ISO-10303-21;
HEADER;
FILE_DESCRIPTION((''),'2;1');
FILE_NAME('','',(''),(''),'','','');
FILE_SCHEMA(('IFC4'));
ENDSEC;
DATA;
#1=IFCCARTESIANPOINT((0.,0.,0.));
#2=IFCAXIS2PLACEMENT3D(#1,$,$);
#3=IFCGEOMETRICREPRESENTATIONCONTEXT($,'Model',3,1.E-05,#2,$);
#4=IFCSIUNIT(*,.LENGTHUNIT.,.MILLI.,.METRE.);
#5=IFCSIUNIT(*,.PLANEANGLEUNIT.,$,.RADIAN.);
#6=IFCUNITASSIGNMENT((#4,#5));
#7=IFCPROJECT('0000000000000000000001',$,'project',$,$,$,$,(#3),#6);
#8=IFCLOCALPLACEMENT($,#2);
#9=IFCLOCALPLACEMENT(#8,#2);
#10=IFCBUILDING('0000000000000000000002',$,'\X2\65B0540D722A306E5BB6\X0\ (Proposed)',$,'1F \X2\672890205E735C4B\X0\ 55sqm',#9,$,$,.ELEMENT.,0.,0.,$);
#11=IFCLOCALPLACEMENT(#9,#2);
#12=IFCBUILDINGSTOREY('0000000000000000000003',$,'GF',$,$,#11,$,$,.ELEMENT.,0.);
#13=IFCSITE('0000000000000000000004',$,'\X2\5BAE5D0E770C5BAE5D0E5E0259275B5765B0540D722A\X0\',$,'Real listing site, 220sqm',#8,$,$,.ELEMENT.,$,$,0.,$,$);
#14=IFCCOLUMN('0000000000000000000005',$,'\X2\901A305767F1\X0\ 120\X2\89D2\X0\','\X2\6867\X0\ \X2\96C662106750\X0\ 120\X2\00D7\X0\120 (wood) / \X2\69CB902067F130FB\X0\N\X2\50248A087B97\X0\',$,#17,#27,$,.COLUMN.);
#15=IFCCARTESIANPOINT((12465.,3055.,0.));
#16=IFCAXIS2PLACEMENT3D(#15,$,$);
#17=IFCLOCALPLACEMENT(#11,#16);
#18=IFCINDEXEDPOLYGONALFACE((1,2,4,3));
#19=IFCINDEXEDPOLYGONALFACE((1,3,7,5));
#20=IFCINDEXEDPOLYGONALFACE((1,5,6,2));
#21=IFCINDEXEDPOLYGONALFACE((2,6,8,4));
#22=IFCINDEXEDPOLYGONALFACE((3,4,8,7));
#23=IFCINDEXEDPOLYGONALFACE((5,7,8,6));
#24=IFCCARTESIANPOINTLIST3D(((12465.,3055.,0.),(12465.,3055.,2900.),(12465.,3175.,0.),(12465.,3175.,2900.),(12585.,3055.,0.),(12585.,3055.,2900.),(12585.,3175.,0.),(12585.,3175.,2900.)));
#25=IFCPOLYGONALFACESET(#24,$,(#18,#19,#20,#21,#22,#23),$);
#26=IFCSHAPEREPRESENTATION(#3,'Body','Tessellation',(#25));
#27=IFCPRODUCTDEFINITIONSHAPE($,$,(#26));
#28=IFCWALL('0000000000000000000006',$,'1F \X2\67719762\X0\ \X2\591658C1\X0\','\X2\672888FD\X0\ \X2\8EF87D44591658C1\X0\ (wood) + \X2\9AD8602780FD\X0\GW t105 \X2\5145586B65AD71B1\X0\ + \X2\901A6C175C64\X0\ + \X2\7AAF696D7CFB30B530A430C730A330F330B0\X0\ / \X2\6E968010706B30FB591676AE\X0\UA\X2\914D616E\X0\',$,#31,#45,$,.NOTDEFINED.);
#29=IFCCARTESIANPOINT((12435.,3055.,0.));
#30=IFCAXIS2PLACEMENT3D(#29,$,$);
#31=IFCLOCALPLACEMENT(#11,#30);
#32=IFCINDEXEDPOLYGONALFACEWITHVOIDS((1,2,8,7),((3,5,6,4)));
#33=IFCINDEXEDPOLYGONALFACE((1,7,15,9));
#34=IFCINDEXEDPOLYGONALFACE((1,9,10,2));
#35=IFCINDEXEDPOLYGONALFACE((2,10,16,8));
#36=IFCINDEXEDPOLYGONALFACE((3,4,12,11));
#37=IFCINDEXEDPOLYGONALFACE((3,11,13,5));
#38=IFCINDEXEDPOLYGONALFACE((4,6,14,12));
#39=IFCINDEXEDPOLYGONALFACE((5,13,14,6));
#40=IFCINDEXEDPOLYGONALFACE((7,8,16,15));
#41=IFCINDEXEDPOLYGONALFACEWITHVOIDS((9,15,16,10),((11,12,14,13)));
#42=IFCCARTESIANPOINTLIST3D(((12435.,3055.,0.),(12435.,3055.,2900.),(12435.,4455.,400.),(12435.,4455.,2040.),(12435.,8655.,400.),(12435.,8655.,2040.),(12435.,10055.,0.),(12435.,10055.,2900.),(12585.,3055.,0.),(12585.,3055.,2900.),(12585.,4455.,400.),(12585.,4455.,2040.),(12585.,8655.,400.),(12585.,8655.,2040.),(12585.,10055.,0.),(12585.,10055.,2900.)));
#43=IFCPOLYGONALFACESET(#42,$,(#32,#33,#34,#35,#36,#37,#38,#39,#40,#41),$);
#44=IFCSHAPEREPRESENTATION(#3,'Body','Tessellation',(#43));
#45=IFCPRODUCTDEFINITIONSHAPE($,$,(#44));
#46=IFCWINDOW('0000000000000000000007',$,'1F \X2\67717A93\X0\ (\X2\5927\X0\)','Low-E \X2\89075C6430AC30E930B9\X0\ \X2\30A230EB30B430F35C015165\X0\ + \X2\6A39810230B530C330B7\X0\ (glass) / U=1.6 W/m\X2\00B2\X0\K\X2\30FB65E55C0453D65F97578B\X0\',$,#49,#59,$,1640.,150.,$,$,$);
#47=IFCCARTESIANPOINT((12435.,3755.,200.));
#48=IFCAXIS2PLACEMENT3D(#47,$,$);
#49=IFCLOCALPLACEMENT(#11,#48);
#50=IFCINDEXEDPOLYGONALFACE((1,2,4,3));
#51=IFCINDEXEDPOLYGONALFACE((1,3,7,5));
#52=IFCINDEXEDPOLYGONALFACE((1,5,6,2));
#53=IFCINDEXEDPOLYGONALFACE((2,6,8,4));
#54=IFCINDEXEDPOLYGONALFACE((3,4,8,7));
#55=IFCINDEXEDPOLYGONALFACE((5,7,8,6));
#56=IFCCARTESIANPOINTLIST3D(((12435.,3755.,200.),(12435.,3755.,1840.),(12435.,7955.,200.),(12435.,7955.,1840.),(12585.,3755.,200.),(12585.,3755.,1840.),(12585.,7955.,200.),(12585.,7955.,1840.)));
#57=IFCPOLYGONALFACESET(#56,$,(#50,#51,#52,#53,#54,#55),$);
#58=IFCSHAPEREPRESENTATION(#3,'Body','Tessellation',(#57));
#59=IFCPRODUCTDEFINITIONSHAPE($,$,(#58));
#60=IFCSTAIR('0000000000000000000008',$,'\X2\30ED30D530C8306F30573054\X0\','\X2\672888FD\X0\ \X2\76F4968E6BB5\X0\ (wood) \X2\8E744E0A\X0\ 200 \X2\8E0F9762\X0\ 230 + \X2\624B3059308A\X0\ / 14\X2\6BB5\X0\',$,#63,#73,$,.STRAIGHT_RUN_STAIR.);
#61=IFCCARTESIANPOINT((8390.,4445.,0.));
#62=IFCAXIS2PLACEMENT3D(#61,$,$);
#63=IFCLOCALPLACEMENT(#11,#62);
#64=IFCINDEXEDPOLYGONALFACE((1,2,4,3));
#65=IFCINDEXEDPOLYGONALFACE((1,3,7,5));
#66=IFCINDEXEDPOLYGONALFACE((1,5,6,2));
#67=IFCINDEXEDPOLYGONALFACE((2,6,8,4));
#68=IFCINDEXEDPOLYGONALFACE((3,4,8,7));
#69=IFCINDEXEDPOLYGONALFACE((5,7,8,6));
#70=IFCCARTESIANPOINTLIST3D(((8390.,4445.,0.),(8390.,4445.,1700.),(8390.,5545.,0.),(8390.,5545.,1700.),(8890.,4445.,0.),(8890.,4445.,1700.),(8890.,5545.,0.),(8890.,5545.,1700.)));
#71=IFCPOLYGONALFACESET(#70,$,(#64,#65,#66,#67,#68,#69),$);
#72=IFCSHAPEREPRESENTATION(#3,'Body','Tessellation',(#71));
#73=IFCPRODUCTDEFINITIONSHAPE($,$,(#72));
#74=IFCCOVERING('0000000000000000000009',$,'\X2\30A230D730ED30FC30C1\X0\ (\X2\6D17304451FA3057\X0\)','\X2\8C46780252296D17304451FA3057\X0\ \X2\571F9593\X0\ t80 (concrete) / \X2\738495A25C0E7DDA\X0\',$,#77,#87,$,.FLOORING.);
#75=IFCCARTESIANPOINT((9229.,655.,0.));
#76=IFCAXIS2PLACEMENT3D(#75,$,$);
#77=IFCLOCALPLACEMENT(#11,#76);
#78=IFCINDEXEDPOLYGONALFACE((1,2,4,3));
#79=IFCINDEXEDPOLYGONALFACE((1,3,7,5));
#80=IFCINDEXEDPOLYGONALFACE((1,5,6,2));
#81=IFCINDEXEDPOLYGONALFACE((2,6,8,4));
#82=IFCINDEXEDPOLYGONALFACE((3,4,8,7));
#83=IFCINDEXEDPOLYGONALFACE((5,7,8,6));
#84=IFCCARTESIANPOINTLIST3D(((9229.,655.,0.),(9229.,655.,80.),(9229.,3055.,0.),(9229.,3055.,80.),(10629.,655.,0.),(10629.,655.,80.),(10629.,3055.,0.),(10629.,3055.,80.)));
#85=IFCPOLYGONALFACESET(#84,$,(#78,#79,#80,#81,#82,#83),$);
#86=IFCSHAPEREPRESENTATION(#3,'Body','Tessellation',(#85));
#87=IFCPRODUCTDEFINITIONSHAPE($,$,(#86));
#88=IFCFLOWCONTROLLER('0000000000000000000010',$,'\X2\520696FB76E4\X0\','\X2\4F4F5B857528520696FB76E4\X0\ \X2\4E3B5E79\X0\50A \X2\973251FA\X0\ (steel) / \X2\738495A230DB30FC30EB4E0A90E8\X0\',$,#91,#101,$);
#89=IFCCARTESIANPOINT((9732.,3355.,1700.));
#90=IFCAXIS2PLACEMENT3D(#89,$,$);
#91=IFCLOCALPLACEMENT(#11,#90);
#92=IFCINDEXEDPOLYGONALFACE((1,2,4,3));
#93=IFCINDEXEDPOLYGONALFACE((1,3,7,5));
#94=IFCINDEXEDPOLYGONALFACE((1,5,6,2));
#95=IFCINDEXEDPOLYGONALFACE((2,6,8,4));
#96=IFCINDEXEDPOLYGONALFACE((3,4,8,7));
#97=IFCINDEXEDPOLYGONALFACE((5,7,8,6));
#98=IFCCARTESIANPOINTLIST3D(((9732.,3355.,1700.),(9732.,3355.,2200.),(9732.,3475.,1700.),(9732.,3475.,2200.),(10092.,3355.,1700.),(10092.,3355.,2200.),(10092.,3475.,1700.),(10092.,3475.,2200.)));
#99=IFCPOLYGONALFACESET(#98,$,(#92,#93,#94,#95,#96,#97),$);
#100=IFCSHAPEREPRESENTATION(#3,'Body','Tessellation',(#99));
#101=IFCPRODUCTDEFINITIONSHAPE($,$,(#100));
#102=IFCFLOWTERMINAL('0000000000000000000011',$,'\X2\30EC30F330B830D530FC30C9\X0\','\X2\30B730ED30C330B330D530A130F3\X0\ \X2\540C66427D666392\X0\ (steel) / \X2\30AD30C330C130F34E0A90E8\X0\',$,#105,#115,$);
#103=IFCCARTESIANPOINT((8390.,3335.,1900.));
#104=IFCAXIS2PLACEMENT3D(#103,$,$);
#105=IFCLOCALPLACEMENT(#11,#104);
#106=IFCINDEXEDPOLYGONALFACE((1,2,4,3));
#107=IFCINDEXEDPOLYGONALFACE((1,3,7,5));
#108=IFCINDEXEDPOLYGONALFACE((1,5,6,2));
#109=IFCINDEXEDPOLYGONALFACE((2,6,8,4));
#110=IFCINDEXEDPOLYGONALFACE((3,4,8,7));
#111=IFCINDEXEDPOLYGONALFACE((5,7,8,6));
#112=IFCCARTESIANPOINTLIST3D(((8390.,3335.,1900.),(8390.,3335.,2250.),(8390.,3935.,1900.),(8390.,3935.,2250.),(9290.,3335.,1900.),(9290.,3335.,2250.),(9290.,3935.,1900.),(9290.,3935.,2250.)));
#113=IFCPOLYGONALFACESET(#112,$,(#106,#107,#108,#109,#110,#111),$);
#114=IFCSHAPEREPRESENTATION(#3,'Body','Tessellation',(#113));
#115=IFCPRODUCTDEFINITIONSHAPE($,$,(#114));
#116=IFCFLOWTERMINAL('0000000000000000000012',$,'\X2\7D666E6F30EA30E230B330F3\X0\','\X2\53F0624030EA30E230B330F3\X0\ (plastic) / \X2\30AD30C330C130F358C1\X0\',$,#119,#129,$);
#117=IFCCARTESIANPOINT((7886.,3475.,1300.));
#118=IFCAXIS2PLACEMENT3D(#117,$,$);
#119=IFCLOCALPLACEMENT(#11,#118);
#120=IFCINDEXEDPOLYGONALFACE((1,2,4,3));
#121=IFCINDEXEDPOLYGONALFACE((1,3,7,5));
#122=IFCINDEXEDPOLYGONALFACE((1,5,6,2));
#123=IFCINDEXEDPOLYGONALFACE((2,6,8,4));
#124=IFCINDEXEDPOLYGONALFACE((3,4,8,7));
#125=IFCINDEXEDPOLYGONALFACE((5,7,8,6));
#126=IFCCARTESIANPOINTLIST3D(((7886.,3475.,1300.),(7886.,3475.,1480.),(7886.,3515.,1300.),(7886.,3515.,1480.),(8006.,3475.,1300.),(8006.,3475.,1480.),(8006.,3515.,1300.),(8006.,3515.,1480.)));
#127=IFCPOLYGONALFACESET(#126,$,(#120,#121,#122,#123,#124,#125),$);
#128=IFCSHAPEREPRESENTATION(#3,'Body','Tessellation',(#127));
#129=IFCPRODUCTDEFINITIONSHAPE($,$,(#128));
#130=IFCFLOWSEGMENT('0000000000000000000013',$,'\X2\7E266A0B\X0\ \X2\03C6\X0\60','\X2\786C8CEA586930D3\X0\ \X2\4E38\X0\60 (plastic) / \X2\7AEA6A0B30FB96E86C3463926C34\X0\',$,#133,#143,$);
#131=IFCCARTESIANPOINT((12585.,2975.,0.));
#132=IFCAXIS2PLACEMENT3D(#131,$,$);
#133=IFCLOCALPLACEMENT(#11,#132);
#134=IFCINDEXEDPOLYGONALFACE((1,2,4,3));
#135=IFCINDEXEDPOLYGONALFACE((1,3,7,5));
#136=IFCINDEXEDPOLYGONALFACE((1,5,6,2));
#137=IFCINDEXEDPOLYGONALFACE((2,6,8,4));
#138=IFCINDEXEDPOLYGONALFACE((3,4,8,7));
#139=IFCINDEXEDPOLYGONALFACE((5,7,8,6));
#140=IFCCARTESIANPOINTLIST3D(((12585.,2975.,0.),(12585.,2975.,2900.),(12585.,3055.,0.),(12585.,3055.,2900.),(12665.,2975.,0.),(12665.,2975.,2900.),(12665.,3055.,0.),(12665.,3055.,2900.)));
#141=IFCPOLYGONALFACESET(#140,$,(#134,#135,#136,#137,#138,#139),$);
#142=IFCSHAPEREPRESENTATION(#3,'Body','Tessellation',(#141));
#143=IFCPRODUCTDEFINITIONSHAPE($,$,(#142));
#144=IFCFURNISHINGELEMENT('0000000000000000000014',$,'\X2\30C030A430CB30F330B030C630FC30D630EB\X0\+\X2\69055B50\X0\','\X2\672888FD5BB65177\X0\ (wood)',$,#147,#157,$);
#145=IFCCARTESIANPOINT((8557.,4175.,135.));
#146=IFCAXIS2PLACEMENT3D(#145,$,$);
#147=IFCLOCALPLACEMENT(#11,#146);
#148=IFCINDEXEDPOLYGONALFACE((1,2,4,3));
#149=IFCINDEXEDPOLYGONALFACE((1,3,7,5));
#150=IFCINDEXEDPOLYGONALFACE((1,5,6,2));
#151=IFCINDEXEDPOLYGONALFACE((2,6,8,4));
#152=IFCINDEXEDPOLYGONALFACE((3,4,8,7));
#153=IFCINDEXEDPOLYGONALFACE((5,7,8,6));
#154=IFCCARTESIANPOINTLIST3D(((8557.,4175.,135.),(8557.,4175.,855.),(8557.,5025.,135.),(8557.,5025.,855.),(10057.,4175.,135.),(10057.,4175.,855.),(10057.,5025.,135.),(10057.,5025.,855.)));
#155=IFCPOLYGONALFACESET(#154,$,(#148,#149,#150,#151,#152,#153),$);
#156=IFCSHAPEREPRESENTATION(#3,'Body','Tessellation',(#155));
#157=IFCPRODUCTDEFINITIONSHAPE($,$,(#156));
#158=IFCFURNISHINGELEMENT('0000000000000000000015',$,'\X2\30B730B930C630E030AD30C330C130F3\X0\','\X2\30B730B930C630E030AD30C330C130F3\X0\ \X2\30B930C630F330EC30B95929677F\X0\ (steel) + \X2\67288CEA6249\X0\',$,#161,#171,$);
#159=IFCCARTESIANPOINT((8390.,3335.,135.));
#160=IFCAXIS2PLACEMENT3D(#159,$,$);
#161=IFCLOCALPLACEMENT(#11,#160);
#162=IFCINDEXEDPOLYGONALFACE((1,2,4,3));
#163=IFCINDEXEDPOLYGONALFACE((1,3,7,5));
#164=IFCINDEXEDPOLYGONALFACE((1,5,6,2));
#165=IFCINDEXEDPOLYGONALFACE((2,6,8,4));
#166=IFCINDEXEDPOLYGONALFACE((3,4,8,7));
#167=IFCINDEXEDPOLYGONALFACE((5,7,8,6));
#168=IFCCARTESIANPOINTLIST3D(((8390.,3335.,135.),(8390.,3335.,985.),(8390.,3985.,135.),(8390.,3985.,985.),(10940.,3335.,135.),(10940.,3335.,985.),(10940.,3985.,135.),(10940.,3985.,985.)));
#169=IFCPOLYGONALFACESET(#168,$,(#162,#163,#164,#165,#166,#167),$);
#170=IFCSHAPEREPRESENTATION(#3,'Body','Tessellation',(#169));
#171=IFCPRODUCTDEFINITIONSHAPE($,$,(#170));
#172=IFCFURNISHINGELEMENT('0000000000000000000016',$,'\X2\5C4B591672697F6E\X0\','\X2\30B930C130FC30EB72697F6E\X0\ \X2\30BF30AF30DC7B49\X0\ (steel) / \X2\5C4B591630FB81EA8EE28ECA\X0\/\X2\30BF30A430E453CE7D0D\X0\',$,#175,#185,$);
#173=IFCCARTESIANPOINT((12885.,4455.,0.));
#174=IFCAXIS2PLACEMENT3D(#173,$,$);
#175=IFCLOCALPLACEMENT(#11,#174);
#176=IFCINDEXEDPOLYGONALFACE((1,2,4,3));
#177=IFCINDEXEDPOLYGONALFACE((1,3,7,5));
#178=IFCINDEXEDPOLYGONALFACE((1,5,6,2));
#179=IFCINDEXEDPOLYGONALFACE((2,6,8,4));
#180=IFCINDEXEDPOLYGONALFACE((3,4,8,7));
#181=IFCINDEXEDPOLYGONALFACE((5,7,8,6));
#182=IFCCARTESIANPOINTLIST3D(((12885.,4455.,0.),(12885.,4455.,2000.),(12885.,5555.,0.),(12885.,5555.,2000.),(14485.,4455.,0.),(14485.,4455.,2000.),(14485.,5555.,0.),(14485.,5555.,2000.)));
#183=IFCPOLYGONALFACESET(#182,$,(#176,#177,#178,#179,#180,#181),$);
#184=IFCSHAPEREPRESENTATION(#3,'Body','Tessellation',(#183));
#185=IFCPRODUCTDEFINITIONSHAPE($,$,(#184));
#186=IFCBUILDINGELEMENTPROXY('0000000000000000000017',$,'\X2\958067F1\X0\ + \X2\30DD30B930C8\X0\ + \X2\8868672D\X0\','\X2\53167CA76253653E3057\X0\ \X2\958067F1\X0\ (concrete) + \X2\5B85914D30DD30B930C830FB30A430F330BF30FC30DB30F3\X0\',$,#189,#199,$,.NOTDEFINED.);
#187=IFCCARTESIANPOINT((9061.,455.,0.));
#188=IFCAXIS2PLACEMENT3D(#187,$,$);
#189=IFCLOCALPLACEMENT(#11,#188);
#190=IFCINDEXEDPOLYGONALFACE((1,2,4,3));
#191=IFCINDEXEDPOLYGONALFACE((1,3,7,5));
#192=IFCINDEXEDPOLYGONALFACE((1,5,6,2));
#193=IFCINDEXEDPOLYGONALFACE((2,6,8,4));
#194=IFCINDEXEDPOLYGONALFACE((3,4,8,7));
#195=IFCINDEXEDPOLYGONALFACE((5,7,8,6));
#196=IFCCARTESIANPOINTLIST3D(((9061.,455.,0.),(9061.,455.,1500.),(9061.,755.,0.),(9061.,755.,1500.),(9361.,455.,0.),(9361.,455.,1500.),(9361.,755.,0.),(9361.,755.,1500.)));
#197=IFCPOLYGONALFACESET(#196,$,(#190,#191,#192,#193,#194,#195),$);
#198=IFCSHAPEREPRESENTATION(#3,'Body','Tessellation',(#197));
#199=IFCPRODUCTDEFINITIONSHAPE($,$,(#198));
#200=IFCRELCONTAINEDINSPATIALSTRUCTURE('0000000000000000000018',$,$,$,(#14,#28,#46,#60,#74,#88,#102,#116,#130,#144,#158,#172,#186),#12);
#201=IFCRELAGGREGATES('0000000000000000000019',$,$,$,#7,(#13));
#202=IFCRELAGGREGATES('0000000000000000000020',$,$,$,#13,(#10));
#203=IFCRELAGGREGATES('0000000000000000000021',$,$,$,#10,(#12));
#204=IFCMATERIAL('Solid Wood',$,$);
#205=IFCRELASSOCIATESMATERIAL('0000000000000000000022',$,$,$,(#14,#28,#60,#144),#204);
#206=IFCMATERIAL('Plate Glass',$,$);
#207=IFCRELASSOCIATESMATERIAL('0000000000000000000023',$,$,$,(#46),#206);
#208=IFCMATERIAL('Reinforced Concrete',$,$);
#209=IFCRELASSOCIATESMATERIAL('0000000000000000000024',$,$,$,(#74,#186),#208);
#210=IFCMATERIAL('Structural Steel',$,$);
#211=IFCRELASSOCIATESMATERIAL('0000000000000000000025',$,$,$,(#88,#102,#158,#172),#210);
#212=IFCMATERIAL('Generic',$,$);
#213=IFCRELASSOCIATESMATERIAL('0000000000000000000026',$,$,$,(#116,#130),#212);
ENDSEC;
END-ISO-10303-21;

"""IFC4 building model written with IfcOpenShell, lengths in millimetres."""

from ifc_helpers import new_model, si_unit, frame, frame_2d, origin, place, context, project, spatial, rectangle, extrude, material, element, fill, save


model = new_model("IFC4")

# Units and contexts
model_context = context("Model", 3, precision=1e-05, world=origin())
ifc_project = project(units=[si_unit("LENGTHUNIT", "METRE", prefix="MILLI"), si_unit("PLANEANGLEUNIT", "RADIAN")], contexts=[model_context])

# Site, building, storey
site_placement = place(None, origin())
site = spatial("IfcSite", under=ifc_project, at=site_placement, Name="宮崎県宮崎市大字新名爪", ObjectType="Real listing site, 220sqm", CompositionType="ELEMENT", RefElevation=0.0)
building_placement = place(site_placement, origin())
building = spatial("IfcBuilding", under=site, at=building_placement, Name="新名爪の家 (Proposed)", ObjectType="1F 木造平屋 55sqm", CompositionType="ELEMENT", ElevationOfRefHeight=0.0, ElevationOfTerrain=0.0)
storey_placement = place(building_placement, origin())
storey = spatial("IfcBuildingStorey", under=building, at=storey_placement, Name="GF", CompositionType="ELEMENT", Elevation=0.0)

# Column
ifc_material_1 = material(Name="Solid Wood")
column_1_placement = place(storey_placement, frame((12465.0, 3055.0, 0.0)))
element("IfcColumn", 1, at=column_1_placement, inside=storey, material=ifc_material_1, Name="通し柱 120角", Description="桧 集成材 120×120 (wood) / 構造柱・N値計算", PredefinedType="COLUMN", context=model_context, shape_type="SweptSolid", body=[
    extrude(rectangle(XDim=120.0, YDim=120.0, at=frame_2d((60.0, 60.0))), frame((12465.0, 3055.0, 0.0)), (0.0, 0.0, 1.0), 2900.0),
])

# Wall, opening, window
wall_1_placement = place(storey_placement, frame((12435.0, 3055.0, 0.0)))
wall_1 = element("IfcWall", 2, at=wall_1_placement, inside=storey, material=ifc_material_1, Name="1F 東面 外壁", Description="木製 軸組外壁 (wood) + 高性能GW t105 充填断熱 + 通気層 + 窯業系サイディング / 準耐火・外皮UA配慮", PredefinedType="NOTDEFINED", context=model_context, shape_type="SweptSolid", body=[
    extrude(rectangle(XDim=150.0, YDim=7000.0, at=frame_2d((75.0, 3500.0))), frame((12435.0, 3055.0, 0.0)), (0.0, 0.0, 1.0), 2900.0),
])
opening_placement = place(storey_placement, frame((12435.0, 3755.0, 200.0)))
opening = element("IfcOpeningElement", 3, at=opening_placement, cuts=wall_1, PredefinedType="NOTDEFINED", context=model_context, shape_type="SweptSolid", body=[
    extrude(rectangle(XDim=150.0, YDim=4200.0, at=frame_2d((75.0, 2100.0))), frame((12435.0, 3755.0, 200.0)), (0.0, 0.0, 1.0), 1640.0),
])
ifc_material_2 = material(Name="Plate Glass")
window_placement = place(storey_placement, frame((12435.0, 3755.0, 200.0)))
window = element("IfcWindow", 4, at=window_placement, inside=storey, material=ifc_material_2, Name="1F 東窓 (大)", Description="Low-E 複層ガラス アルゴン封入 + 樹脂サッシ (glass) / U=1.6 W/m²K・日射取得型", OverallHeight=1640.0, OverallWidth=150.0, context=model_context, shape_type="SweptSolid", body=[
    extrude(rectangle(XDim=150.0, YDim=4200.0, at=frame_2d((75.0, 2100.0))), frame((12435.0, 3755.0, 200.0)), (0.0, 0.0, 1.0), 1640.0),
])
fill(opening, window)

# Stair
stair_placement = place(storey_placement, frame((8390.0, 4445.0, 0.0)))
element("IfcStair", 5, at=stair_placement, inside=storey, material=ifc_material_1, Name="ロフトはしご", Description="木製 直階段 (wood) 蹴上 200 踏面 230 + 手すり / 14段", PredefinedType="STRAIGHT_RUN_STAIR", context=model_context, shape_type="SweptSolid", body=[
    extrude(rectangle(XDim=500.0, YDim=1100.0, at=frame_2d((250.0, 550.0))), frame((8390.0, 4445.0, 0.0)), (0.0, 0.0, 1.0), 1700.0),
])

# Covering
ifc_material_3 = material(Name="Reinforced Concrete")
covering_placement = place(storey_placement, frame((9229.0, 655.0, 0.0)))
element("IfcCovering", 6, at=covering_placement, inside=storey, material=ifc_material_3, Name="アプローチ (洗い出し)", Description="豆砂利洗い出し 土間 t80 (concrete) / 玄関導線", PredefinedType="FLOORING", context=model_context, shape_type="SweptSolid", body=[
    extrude(rectangle(XDim=1400.0, YDim=2400.0, at=frame_2d((700.0, 1200.0))), frame((9229.0, 655.0, 0.0)), (0.0, 0.0, 1.0), 80.0),
])

# Flow controller
ifc_material_4 = material(Name="Structural Steel")
flow_controller_placement = place(storey_placement, frame((9732.0, 3355.0, 1700.0)))
element("IfcFlowController", 7, at=flow_controller_placement, inside=storey, material=ifc_material_4, Name="分電盤", Description="住宅用分電盤 主幹50A 露出 (steel) / 玄関ホール上部", context=model_context, shape_type="SweptSolid", body=[
    extrude(rectangle(XDim=360.0, YDim=120.0, at=frame_2d((180.0, 60.0))), frame((9732.0, 3355.0, 1700.0)), (0.0, 0.0, 1.0), 500.0),
])

# Flow terminals
flow_terminal_1_placement = place(storey_placement, frame((8390.0, 3335.0, 1900.0)))
element("IfcFlowTerminal", 8, at=flow_terminal_1_placement, inside=storey, material=ifc_material_4, Name="レンジフード", Description="シロッコファン 同時給排 (steel) / キッチン上部", context=model_context, shape_type="SweptSolid", body=[
    extrude(rectangle(XDim=900.0, YDim=600.0, at=frame_2d((450.0, 300.0))), frame((8390.0, 3335.0, 1900.0)), (0.0, 0.0, 1.0), 350.0),
])
ifc_material_5 = material(Name="Generic")
flow_terminal_2_placement = place(storey_placement, frame((7886.0, 3475.0, 1300.0)))
element("IfcFlowTerminal", 9, at=flow_terminal_2_placement, inside=storey, material=ifc_material_5, Name="給湯リモコン", Description="台所リモコン (plastic) / キッチン壁", context=model_context, shape_type="SweptSolid", body=[
    extrude(rectangle(XDim=120.0, YDim=40.0, at=frame_2d((60.0, 20.0))), frame((7886.0, 3475.0, 1300.0)), (0.0, 0.0, 1.0), 180.0),
])

# Flow segment
flow_segment_placement = place(storey_placement, frame((12585.0, 2975.0, 0.0)))
element("IfcFlowSegment", 10, at=flow_segment_placement, inside=storey, material=ifc_material_5, Name="縦樋 φ60", Description="硬質塩ビ 丸60 (plastic) / 竪樋・雨水排水", context=model_context, shape_type="SweptSolid", body=[
    extrude(rectangle(XDim=80.0, YDim=80.0, at=frame_2d((40.0, 40.0))), frame((12585.0, 2975.0, 0.0)), (0.0, 0.0, 1.0), 2900.0),
])

# Furnishing elements
furnishing_1_placement = place(storey_placement, frame((8557.0, 4175.0, 135.0)))
element("IfcFurnishingElement", 11, at=furnishing_1_placement, inside=storey, material=ifc_material_1, Name="ダイニングテーブル+椅子", Description="木製家具 (wood)", context=model_context, shape_type="SweptSolid", body=[
    extrude(rectangle(XDim=1500.0, YDim=850.0, at=frame_2d((750.0, 425.0))), frame((8557.0, 4175.0, 135.0)), (0.0, 0.0, 1.0), 720.0),
])
furnishing_2_placement = place(storey_placement, frame((8390.0, 3335.0, 135.0)))
element("IfcFurnishingElement", 12, at=furnishing_2_placement, inside=storey, material=ifc_material_4, Name="システムキッチン", Description="システムキッチン ステンレス天板 (steel) + 木質扉", context=model_context, shape_type="SweptSolid", body=[
    extrude(rectangle(XDim=2550.0, YDim=650.0, at=frame_2d((1275.0, 325.0))), frame((8390.0, 3335.0, 135.0)), (0.0, 0.0, 1.0), 850.0),
])
furnishing_3_placement = place(storey_placement, frame((12885.0, 4455.0, 0.0)))
element("IfcFurnishingElement", 13, at=furnishing_3_placement, inside=storey, material=ifc_material_4, Name="屋外物置", Description="スチール物置 タクボ等 (steel) / 屋外・自転車/タイヤ収納", context=model_context, shape_type="SweptSolid", body=[
    extrude(rectangle(XDim=1600.0, YDim=1100.0, at=frame_2d((800.0, 550.0))), frame((12885.0, 4455.0, 0.0)), (0.0, 0.0, 1.0), 2000.0),
])

# Building element proxy
proxy_placement = place(storey_placement, frame((9061.0, 455.0, 0.0)))
element("IfcBuildingElementProxy", 14, at=proxy_placement, inside=storey, material=ifc_material_3, Name="門柱 + ポスト + 表札", Description="化粧打放し 門柱 (concrete) + 宅配ポスト・インターホン", PredefinedType="NOTDEFINED", context=model_context, shape_type="SweptSolid", body=[
    extrude(rectangle(XDim=300.0, YDim=300.0, at=frame_2d((150.0, 150.0))), frame((9061.0, 455.0, 0.0)), (0.0, 0.0, 1.0), 1500.0),
])

save(model, "model.ifc")
